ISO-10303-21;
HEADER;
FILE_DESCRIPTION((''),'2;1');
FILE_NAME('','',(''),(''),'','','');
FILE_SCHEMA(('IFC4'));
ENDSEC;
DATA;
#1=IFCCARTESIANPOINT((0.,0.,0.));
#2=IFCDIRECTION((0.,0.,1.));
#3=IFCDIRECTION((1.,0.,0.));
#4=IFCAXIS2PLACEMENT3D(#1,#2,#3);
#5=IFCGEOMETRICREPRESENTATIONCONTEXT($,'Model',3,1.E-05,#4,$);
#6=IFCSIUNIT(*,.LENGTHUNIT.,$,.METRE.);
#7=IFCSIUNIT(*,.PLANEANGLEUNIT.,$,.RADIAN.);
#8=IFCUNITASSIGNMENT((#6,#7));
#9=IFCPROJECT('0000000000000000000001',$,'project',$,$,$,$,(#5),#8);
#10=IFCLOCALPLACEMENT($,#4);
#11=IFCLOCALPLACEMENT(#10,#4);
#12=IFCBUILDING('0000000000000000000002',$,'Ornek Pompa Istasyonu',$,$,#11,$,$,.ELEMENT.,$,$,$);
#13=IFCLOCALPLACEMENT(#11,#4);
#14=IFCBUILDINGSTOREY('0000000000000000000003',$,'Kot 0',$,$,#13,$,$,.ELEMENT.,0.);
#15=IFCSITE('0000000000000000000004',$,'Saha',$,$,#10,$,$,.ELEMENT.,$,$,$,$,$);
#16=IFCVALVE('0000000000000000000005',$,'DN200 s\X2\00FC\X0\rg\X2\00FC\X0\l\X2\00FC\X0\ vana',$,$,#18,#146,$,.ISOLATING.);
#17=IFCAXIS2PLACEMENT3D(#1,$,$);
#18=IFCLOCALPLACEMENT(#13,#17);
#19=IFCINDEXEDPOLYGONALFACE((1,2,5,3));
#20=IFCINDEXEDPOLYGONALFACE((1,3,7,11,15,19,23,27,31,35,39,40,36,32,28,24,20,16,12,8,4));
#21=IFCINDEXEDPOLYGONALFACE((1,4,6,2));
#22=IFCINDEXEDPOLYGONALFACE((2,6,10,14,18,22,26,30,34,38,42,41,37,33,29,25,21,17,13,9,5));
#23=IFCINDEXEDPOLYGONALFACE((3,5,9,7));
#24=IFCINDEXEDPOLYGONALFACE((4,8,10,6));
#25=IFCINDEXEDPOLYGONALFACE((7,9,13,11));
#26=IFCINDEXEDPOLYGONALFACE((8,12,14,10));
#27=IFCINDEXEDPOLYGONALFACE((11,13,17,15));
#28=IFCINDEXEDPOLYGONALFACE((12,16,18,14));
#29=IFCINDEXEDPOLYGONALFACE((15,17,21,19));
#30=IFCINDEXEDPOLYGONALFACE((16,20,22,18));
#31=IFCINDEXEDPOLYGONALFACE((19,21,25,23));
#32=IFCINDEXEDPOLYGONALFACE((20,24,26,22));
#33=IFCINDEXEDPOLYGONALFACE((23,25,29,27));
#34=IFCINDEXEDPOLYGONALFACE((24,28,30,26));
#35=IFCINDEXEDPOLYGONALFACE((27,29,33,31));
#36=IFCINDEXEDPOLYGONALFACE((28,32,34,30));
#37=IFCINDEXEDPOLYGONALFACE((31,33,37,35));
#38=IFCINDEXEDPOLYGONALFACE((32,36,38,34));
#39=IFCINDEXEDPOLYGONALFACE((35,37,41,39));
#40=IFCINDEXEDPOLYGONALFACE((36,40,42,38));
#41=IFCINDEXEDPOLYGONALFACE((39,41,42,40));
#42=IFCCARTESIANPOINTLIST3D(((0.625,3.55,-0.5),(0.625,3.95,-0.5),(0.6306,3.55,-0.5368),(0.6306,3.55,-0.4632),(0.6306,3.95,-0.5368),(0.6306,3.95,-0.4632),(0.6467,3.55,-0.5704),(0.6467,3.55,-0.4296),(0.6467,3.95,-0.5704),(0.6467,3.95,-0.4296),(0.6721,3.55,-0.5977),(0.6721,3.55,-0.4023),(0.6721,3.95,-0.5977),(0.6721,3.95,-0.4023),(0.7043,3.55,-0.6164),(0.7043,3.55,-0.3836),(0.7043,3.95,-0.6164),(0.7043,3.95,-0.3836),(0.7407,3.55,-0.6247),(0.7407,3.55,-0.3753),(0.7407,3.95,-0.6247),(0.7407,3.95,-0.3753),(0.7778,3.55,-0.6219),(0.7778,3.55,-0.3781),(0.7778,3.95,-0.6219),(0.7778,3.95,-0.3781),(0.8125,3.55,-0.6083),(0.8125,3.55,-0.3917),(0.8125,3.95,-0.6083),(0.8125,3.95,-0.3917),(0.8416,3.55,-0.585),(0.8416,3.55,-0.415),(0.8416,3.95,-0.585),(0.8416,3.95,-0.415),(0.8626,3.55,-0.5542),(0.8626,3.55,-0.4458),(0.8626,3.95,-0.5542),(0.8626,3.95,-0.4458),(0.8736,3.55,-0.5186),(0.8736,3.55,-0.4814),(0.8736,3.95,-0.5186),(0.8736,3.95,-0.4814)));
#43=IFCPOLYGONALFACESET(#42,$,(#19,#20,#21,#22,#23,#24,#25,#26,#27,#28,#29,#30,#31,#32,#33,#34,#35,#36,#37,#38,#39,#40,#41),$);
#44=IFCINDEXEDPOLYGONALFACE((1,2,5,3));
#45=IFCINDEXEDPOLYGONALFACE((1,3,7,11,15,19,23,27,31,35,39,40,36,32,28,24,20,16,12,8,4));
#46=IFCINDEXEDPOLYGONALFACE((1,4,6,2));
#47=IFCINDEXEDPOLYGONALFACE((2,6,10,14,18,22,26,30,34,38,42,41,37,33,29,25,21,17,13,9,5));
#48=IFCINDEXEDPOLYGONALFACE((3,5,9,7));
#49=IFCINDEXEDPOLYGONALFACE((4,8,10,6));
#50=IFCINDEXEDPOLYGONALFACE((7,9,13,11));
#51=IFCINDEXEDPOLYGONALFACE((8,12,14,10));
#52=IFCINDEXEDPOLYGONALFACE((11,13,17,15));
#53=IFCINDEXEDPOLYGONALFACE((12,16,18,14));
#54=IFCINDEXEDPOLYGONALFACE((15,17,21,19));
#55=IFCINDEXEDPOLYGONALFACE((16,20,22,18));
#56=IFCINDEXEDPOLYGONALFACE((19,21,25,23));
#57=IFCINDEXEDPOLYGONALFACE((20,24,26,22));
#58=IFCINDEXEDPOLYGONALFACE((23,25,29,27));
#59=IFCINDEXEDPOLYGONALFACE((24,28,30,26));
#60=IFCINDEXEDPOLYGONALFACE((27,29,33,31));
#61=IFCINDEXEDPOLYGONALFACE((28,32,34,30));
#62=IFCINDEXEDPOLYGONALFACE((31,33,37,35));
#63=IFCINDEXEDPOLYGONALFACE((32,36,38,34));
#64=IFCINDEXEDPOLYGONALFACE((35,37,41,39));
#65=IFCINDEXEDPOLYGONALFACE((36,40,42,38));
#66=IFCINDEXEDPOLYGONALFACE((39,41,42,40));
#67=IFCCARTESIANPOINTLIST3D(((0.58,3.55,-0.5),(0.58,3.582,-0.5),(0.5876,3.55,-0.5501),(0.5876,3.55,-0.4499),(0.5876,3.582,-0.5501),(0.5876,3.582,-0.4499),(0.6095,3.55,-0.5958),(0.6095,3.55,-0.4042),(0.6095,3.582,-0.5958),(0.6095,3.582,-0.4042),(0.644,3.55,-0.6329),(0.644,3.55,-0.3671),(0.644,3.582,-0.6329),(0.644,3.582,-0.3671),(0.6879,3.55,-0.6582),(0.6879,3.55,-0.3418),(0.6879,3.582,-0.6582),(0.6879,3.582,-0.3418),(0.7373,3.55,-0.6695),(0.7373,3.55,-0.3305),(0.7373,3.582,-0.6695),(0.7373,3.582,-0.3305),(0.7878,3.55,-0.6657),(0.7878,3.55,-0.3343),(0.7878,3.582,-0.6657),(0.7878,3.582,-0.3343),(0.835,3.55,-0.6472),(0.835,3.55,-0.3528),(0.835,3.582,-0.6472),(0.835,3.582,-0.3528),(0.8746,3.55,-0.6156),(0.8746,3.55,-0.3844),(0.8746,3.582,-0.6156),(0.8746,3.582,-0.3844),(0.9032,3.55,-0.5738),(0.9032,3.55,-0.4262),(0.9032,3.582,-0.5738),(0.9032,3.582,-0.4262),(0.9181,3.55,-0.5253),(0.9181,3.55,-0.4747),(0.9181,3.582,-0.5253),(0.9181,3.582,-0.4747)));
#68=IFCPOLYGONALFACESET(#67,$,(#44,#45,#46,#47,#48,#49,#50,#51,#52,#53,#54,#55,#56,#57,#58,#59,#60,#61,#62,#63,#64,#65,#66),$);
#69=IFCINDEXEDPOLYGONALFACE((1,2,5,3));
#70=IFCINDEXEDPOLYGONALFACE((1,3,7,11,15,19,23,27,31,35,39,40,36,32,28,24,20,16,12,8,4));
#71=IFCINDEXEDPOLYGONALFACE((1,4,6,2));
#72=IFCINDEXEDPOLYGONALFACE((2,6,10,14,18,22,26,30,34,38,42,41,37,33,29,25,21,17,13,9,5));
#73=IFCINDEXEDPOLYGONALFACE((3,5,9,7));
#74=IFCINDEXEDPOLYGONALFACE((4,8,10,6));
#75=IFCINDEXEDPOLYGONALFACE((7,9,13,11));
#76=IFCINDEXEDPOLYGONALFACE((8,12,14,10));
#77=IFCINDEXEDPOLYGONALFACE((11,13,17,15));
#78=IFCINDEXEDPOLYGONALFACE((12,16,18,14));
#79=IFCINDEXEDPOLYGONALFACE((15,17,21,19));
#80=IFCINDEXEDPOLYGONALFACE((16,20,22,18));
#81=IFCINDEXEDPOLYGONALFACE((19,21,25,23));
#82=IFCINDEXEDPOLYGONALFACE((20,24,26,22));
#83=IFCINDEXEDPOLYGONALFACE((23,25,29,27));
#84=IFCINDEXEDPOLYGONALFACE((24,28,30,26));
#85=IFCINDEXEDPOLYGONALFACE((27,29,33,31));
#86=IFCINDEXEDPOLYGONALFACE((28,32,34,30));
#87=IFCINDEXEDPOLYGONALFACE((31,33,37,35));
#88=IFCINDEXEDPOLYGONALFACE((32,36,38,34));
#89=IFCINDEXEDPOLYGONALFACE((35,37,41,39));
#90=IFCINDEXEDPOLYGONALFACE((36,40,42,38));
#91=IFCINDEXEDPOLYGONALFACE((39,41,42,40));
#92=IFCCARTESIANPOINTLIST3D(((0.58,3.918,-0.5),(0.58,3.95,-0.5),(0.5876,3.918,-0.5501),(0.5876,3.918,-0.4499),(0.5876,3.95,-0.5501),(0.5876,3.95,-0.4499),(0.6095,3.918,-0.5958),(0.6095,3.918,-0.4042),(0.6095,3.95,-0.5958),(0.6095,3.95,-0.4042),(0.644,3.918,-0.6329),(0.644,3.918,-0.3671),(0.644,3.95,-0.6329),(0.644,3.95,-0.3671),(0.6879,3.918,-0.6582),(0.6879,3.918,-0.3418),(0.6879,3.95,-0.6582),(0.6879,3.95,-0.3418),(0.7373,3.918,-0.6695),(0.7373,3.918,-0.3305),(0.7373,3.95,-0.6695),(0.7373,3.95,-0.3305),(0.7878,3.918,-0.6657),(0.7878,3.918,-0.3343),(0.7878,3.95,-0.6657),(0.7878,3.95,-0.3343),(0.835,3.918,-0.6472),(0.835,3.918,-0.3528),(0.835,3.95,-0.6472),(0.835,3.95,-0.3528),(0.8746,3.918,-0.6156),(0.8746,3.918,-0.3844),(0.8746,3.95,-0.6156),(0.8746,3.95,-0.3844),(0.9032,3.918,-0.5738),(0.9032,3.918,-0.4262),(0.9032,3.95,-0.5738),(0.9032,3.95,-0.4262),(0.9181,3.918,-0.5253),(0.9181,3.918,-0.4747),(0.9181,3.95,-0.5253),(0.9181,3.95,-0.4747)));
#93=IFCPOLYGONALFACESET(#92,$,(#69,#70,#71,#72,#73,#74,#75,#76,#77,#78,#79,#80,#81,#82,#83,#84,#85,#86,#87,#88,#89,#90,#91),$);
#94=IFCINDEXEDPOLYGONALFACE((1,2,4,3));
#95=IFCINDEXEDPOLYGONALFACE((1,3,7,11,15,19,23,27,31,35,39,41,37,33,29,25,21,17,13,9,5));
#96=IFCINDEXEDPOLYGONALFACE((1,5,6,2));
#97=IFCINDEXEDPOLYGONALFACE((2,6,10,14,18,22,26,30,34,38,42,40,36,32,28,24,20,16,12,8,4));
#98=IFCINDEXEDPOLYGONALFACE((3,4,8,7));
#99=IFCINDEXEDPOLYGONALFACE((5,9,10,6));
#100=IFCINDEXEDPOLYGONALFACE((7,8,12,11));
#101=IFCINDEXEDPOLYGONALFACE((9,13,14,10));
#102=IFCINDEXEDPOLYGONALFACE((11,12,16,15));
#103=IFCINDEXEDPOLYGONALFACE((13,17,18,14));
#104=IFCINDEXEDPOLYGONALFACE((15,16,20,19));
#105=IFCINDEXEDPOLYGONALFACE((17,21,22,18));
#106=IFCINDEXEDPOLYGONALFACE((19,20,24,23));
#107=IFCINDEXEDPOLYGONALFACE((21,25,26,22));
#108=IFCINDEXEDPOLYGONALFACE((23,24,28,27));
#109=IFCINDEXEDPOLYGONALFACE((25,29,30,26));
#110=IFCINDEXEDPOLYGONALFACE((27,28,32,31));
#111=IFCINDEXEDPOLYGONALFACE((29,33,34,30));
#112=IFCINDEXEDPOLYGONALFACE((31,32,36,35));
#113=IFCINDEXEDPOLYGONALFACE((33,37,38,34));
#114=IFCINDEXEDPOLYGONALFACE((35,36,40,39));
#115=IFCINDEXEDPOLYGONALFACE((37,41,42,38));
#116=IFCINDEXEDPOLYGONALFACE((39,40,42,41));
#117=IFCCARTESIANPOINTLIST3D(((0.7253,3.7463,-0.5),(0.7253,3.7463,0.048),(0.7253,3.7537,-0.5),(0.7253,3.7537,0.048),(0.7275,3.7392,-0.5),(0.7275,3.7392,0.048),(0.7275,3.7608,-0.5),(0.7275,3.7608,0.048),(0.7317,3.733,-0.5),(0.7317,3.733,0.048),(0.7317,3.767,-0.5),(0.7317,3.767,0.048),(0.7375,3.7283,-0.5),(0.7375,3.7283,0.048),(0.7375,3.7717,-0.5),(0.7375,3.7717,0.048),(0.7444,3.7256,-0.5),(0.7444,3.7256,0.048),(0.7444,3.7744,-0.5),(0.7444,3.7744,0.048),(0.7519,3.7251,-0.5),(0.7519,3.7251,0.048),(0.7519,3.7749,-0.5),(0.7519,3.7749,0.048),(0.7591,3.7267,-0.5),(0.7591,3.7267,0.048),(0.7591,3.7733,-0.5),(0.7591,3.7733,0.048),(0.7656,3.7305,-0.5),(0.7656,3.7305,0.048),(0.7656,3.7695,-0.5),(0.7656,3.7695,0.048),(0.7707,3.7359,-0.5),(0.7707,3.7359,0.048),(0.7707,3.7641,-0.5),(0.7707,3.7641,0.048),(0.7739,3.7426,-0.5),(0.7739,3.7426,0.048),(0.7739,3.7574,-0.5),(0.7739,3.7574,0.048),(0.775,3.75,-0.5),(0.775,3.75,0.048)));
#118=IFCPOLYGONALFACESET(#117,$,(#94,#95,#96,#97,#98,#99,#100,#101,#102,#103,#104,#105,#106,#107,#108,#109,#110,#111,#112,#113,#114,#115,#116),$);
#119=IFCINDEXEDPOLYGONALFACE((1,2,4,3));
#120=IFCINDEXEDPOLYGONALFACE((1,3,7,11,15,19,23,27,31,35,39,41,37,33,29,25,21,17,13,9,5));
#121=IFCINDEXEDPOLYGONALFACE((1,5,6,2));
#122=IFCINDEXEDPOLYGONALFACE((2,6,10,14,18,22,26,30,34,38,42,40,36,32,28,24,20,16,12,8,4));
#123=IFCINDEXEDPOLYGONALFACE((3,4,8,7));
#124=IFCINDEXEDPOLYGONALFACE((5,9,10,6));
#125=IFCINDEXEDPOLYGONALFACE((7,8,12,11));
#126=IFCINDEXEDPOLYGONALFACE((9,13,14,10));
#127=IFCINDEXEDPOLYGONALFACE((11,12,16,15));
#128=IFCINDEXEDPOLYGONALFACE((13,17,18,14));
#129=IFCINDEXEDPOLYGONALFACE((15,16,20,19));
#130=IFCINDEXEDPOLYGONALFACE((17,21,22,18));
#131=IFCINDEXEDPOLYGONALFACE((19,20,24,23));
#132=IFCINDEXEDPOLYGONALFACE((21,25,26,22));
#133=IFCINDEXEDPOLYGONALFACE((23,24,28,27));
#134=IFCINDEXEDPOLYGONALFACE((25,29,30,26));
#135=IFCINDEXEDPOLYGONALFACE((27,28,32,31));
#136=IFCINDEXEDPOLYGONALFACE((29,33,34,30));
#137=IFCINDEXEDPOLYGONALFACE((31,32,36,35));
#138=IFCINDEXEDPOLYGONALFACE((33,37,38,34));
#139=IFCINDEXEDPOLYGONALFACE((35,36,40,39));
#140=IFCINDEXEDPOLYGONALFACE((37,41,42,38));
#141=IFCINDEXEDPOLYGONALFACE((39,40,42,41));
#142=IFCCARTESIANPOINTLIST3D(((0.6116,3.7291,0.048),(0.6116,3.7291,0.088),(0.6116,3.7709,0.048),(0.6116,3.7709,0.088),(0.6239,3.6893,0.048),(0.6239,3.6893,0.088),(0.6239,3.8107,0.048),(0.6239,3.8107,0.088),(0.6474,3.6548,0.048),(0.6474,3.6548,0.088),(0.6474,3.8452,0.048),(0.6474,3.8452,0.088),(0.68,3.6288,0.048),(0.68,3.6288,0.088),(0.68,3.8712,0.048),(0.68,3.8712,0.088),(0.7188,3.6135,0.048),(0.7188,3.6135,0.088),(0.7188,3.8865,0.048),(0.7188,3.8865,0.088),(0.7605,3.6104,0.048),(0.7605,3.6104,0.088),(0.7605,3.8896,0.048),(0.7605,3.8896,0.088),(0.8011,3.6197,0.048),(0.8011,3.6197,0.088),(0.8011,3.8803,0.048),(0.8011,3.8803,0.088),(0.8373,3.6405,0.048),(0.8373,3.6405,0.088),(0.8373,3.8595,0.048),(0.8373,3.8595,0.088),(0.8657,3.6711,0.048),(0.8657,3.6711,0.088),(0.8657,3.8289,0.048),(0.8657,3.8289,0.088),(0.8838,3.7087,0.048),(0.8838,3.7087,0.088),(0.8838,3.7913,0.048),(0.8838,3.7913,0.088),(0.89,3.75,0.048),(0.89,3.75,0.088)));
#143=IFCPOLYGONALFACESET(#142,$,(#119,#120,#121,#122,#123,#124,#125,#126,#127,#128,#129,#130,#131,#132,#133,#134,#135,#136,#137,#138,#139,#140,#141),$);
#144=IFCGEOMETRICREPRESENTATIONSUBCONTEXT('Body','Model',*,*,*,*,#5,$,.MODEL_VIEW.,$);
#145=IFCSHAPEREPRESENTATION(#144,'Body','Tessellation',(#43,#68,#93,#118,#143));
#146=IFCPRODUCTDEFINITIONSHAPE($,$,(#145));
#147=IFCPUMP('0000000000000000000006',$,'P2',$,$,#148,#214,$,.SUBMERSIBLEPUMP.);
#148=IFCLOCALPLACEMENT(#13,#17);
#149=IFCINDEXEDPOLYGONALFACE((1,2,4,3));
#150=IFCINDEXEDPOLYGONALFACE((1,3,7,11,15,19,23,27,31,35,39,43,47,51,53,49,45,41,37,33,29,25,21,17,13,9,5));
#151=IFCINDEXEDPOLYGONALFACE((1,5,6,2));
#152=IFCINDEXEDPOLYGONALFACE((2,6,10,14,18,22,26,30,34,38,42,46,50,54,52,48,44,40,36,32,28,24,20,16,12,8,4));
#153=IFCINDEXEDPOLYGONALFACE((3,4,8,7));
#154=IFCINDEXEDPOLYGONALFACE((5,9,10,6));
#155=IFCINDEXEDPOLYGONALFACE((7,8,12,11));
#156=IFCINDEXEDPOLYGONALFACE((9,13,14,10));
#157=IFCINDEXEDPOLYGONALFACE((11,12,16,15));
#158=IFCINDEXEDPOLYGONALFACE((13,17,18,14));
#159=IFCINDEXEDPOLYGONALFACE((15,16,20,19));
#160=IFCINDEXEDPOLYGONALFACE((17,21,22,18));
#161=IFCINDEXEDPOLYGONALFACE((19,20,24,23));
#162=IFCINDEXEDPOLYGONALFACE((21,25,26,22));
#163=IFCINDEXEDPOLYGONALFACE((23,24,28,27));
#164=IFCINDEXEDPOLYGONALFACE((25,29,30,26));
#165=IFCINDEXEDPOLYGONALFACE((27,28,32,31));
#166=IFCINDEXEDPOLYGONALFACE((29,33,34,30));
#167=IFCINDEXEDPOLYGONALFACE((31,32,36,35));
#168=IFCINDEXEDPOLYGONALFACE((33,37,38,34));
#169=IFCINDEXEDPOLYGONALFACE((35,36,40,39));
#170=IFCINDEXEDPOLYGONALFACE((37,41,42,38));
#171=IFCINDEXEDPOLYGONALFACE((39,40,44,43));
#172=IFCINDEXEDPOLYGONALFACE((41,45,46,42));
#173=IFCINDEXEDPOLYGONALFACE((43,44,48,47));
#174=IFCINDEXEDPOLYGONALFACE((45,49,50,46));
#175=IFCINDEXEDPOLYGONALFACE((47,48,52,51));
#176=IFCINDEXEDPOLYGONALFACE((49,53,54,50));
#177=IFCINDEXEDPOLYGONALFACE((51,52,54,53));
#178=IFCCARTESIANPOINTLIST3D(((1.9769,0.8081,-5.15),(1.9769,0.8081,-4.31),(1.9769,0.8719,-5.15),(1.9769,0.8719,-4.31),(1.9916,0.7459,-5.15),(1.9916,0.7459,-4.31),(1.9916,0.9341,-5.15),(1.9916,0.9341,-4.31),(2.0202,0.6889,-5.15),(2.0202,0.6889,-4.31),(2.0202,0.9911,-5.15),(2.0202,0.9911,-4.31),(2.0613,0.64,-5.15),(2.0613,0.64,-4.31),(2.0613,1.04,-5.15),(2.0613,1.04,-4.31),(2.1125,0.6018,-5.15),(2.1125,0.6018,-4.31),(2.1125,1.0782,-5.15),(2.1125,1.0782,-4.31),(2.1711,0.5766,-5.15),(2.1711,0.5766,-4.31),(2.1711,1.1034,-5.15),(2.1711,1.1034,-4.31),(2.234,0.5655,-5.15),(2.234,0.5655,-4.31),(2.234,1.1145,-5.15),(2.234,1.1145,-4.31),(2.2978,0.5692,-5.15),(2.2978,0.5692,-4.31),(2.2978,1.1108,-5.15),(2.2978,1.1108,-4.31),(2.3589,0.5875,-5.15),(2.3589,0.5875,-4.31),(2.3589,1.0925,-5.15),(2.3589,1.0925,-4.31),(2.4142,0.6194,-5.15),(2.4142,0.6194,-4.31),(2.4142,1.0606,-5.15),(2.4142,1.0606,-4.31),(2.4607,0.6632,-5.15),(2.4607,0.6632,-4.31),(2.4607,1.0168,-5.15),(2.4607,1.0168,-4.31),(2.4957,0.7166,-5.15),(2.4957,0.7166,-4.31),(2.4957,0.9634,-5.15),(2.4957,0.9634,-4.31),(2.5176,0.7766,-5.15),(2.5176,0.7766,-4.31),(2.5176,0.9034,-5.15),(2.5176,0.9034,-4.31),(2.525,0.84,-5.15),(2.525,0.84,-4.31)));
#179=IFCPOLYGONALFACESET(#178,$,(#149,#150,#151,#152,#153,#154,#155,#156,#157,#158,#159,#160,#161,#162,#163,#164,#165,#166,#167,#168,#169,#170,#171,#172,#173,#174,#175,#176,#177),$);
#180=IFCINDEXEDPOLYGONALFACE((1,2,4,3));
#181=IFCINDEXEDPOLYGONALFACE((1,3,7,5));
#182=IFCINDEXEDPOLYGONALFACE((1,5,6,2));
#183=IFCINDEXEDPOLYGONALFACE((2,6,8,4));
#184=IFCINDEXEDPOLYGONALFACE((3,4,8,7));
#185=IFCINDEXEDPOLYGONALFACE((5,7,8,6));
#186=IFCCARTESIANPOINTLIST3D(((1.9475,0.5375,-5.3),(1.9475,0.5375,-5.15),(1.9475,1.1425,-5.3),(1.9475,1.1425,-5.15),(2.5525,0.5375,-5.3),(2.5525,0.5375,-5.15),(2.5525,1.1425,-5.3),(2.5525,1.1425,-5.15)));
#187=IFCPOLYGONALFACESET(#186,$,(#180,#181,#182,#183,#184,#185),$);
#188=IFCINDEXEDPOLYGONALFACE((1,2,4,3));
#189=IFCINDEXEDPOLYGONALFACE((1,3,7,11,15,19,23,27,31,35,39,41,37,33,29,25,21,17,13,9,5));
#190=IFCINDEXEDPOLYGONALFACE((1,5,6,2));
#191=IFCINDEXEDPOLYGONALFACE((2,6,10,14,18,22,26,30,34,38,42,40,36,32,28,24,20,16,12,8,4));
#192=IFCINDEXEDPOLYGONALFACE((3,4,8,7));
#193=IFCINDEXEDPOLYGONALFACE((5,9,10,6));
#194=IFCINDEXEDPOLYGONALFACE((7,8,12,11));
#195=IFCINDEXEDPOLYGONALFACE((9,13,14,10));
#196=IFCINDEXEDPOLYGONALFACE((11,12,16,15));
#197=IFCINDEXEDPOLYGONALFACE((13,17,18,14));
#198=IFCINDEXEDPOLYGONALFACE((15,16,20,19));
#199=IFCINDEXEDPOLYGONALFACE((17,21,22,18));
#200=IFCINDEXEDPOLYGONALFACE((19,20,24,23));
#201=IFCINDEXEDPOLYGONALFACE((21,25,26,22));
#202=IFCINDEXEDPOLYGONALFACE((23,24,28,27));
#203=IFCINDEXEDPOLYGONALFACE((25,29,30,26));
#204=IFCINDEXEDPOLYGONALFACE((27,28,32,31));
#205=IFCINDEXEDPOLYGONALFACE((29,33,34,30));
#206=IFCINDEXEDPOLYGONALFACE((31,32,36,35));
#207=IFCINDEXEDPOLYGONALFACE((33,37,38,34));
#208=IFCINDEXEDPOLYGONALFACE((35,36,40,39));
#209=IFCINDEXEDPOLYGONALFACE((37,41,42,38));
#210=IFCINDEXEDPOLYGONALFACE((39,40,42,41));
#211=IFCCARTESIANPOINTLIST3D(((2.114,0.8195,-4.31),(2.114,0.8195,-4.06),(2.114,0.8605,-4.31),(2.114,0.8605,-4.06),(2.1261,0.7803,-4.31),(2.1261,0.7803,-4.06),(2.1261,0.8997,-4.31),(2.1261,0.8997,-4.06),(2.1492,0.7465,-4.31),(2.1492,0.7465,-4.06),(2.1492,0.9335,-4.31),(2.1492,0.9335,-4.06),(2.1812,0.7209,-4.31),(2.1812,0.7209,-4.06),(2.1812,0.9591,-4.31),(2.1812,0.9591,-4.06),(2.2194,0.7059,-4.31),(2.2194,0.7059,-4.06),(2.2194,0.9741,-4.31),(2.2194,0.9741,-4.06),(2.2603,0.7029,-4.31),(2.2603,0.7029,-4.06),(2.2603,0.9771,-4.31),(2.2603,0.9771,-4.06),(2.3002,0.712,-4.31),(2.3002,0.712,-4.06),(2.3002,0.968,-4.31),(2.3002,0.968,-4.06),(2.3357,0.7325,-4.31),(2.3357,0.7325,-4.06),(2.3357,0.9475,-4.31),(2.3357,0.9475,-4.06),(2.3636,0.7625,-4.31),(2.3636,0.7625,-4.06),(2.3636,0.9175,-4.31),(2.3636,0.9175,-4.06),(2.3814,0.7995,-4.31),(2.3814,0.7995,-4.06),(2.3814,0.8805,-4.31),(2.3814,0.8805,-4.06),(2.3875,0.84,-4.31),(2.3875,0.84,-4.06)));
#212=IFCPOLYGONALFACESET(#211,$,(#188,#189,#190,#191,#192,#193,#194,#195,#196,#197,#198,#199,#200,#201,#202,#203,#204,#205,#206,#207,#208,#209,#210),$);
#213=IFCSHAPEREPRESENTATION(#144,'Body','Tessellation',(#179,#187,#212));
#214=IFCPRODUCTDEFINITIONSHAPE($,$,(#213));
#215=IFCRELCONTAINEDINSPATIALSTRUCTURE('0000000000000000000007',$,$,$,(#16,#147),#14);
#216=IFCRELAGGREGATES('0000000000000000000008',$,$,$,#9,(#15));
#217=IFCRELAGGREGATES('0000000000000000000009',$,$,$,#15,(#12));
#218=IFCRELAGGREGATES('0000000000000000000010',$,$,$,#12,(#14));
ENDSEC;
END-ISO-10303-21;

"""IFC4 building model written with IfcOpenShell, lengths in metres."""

from ifc_helpers import new_model, si_unit, frame, origin_with_axes, origin_2d, place, context, subcontext, project, spatial, polyline, circle, outline, extrude, element, save


model = new_model("IFC4")

# Units and contexts
model_context = context("Model", 3, precision=1e-05, world=origin_with_axes())
body_context = subcontext(model_context, "Body", "Model", "MODEL_VIEW")
ifc_project = project(units=[si_unit("LENGTHUNIT", "METRE"), si_unit("PLANEANGLEUNIT", "RADIAN")], contexts=[model_context])

# Site, building, storey
site_placement = place(None, origin_with_axes())
site = spatial("IfcSite", under=ifc_project, at=site_placement, Name="Saha", CompositionType="ELEMENT")
building_placement = place(site_placement, origin_with_axes())
building = spatial("IfcBuilding", under=site, at=building_placement, Name="Ornek Pompa Istasyonu", CompositionType="ELEMENT")
storey_placement = place(building_placement, origin_with_axes())
storey = spatial("IfcBuildingStorey", under=building, at=storey_placement, Name="Kot 0", CompositionType="ELEMENT", Elevation=0.0)

# Valve
valve_1_placement = place(storey_placement, origin_with_axes())
element("IfcValve", 1, at=valve_1_placement, inside=storey, Name="DN200 sürgülü vana", PredefinedType="ISOLATING", context=body_context, shape_type="SweptSolid", body=[
    extrude(circle(Radius=0.125, at=origin_2d()), frame((0.75, 3.55, -0.5), z_axis=(0.0, 1.0, 0.0), x_axis=(-1.0, 0.0, 0.0)), (0.0, 0.0, 1.0), 0.4),
    extrude(circle(Radius=0.17, at=origin_2d()), frame((0.75, 3.55, -0.5), z_axis=(0.0, 1.0, 0.0), x_axis=(-1.0, 0.0, 0.0)), (0.0, 0.0, 1.0), 0.032),
    extrude(circle(Radius=0.17, at=origin_2d()), frame((0.75, 3.918, -0.5), z_axis=(0.0, 1.0, 0.0), x_axis=(-1.0, 0.0, 0.0)), (0.0, 0.0, 1.0), 0.032),
    extrude(circle(Radius=0.025, at=origin_2d()), frame((0.75, 3.75, -0.5), z_axis=(0.0, 0.0, 1.0), x_axis=(1.0, 0.0, 0.0)), (0.0, 0.0, 1.0), 0.548),
    extrude(circle(Radius=0.14, at=origin_2d()), frame((0.75, 3.75, 0.048), z_axis=(0.0, 0.0, 1.0), x_axis=(1.0, 0.0, 0.0)), (0.0, 0.0, 1.0), 0.04),
])

# Pump
pump_1_placement = place(storey_placement, origin_with_axes())
element("IfcPump", 2, at=pump_1_placement, inside=storey, Name="P2", PredefinedType="SUBMERSIBLEPUMP", context=body_context, shape_type="SweptSolid", body=[
    extrude(circle(Radius=0.275, at=origin_2d()), frame((2.25, 0.84, -5.15), z_axis=(0.0, 0.0, 1.0), x_axis=(1.0, 0.0, 0.0)), (0.0, 0.0, 1.0), 0.84),
    extrude(outline(polyline([(0.0, 0.0), (0.605, 0.0), (0.605, 0.605), (0.0, 0.605), (0.0, 0.0)])), frame((2.5525, 0.5375, -5.3), z_axis=(0.0, 0.0, 1.0), x_axis=(0.0, 1.0, 0.0)), (0.0, 0.0, 1.0), 0.15),
    extrude(circle(Radius=0.1375, at=origin_2d()), frame((2.25, 0.84, -4.31), z_axis=(0.0, 0.0, 1.0), x_axis=(1.0, 0.0, 0.0)), (0.0, 0.0, 1.0), 0.25),
])

save(model, "model.ifc")
